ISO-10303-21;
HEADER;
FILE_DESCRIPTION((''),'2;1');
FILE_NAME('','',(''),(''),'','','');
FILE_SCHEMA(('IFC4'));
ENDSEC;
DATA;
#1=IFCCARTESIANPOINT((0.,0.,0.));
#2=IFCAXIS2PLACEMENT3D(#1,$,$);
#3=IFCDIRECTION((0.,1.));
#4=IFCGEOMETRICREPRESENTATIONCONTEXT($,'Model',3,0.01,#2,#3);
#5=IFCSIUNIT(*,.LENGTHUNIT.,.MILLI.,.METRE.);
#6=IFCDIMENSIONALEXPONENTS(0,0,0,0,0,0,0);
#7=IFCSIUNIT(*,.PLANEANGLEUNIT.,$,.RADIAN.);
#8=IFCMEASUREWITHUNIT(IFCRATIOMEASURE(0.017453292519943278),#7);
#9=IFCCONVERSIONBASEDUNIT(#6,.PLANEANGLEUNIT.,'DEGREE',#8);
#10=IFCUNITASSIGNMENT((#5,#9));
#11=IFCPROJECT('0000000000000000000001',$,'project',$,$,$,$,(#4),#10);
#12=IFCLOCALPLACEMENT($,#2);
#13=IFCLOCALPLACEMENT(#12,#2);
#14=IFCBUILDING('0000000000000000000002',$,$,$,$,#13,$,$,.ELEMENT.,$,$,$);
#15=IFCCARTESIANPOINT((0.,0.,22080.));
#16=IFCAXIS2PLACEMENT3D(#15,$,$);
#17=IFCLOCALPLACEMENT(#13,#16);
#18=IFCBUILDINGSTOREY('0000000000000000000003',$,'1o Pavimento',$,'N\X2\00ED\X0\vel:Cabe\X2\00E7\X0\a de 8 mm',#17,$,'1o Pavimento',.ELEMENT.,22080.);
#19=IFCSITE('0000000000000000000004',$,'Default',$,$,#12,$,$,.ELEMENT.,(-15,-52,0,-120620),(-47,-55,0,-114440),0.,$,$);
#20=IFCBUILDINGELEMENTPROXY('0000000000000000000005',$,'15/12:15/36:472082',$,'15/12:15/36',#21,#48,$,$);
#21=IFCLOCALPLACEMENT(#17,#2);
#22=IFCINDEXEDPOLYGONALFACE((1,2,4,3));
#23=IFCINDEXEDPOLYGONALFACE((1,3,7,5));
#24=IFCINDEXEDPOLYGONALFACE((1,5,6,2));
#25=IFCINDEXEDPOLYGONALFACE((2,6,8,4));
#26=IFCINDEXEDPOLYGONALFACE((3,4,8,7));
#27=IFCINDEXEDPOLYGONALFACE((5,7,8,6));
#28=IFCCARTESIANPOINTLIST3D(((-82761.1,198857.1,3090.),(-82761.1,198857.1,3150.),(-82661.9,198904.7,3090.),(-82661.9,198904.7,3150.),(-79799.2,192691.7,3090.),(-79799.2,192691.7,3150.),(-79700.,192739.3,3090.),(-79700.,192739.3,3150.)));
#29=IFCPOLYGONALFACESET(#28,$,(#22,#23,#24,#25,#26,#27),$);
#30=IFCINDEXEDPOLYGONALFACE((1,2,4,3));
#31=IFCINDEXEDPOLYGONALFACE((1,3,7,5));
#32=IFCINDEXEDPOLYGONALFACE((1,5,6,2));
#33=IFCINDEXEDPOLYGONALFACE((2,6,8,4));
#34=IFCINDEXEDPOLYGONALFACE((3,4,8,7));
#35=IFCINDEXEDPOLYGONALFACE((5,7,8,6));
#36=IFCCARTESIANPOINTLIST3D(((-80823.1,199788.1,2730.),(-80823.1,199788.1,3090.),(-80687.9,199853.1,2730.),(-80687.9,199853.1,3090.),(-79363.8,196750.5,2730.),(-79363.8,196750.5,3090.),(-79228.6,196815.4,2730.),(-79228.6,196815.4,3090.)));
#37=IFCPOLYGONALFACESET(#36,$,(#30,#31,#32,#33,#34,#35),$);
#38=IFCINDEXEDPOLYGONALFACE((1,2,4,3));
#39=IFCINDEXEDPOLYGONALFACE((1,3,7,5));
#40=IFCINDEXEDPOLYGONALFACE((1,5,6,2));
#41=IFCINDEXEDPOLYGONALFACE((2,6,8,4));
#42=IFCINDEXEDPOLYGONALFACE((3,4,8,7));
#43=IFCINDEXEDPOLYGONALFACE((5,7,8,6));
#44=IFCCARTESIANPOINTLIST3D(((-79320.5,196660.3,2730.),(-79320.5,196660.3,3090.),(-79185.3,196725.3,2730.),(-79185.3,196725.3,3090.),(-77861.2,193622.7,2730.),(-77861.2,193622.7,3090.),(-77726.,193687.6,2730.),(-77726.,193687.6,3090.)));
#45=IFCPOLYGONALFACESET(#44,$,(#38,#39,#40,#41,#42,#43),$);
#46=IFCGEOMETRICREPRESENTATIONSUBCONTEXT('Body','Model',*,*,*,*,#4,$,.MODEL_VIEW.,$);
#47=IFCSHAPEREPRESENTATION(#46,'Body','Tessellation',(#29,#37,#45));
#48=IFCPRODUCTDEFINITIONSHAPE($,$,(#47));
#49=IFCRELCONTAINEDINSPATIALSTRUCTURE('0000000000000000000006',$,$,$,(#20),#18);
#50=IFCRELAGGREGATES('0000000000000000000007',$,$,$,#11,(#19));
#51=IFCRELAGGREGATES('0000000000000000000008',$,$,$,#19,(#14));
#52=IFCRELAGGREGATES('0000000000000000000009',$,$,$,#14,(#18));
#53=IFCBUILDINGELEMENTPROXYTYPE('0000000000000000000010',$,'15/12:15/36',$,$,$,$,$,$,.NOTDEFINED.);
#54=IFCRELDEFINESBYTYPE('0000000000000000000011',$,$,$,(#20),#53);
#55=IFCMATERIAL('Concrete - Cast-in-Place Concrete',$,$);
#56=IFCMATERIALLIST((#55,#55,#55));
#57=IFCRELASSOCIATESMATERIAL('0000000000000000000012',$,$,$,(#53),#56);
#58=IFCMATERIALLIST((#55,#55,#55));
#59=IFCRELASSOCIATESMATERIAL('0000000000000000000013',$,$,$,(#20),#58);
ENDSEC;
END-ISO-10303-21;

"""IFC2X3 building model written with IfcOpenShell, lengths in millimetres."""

from ifc_helpers import new_model, entity, si_unit, converted_unit, direction, frame, frame_2d, origin, place, context, subcontext, project, spatial, rectangle, extrude, source, transform, mapped, material, material_list, type_object, type_shapes, element, save


model = new_model("IFC2X3")

# Units and contexts
model_context = context("Model", 3, precision=0.01, world=origin(), true_north=direction((0.0, 1.0)))
body_context = subcontext(model_context, "Body", "Model", "MODEL_VIEW")
ifc_project = project(units=[si_unit("LENGTHUNIT", "METRE", prefix="MILLI"), converted_unit("PLANEANGLEUNIT", "DEGREE", entity("IfcRatioMeasure", 0.017453292519943278), si_unit("PLANEANGLEUNIT", "RADIAN"), dimensions=[0, 0, 0, 0, 0, 0, 0])], contexts=[model_context])

# Site, building, storey
site_placement = place(None, origin())
site = spatial("IfcSite", under=ifc_project, at=site_placement, Name="Default", CompositionType="ELEMENT", RefLatitude=(-15, -52, 0, -120620), RefLongitude=(-47, -55, 0, -114440), RefElevation=0.0)
building_placement = place(site_placement, origin())
building = spatial("IfcBuilding", under=site, at=building_placement, CompositionType="ELEMENT")
storey_placement = place(building_placement, frame((0.0, 0.0, 22080.0)))
storey = spatial("IfcBuildingStorey", under=building, at=storey_placement, Name="1o Pavimento", ObjectType="Nível:Cabeça de 8 mm", LongName="1o Pavimento", CompositionType="ELEMENT", Elevation=22080.0)

# Building element proxy
ifc_material_1 = material(Name="Concrete - Cast-in-Place Concrete")
ifc_material_list_1 = material_list([ifc_material_1, ifc_material_1, ifc_material_1])
ifc_material_list_2 = material_list([ifc_material_1, ifc_material_1, ifc_material_1])
building_element_proxy_type_1 = type_object("IfcBuildingElementProxyType", Name="15/12:15/36", PredefinedType="NOTDEFINED", material=ifc_material_list_2)
shared_shape_1 = source(origin(), body_context, "Body", "SweptSolid", [
    extrude(rectangle(XDim=110.0, YDim=6840.0, at=frame_2d((0.0, 0.0), x_axis=(1.0, 0.0))), frame((1530.5, 3106.5, 360.0), z_axis=(0.0, 0.0, 1.0), x_axis=(0.90138, 0.43303, 0.0)), (0.0, 0.0, 1.0), 60.0),
    extrude(rectangle(XDim=3370.0, YDim=150.0, at=frame_2d((0.0, 0.0), x_axis=(1.0, 0.0))), frame((2735.2, 5610.1, 0.0), z_axis=(0.0, 0.0, 1.0), x_axis=(0.43303, -0.90138, 0.0)), (0.0, 0.0, 1.0), 360.0),
    extrude(rectangle(XDim=3370.0, YDim=150.0, at=frame_2d((0.0, 0.0), x_axis=(1.0, 0.0))), frame((4237.8, 2482.3, 0.0), z_axis=(0.0, 0.0, 1.0), x_axis=(0.43303, -0.90138, 0.0)), (0.0, 0.0, 1.0), 360.0),
])
type_shapes(building_element_proxy_type_1, [shared_shape_1])
proxy_1_placement = place(storey_placement, frame((-82761.1, 192691.7, 2730.0)))
element("IfcBuildingElementProxy", 1, at=proxy_1_placement, inside=storey, type_object=building_element_proxy_type_1, material=ifc_material_list_1, Name="15/12:15/36:472082", ObjectType="15/12:15/36", context=body_context, shape_type="MappedRepresentation", body=[
    mapped(shared_shape_1, transform((0.0, 0.0, 0.0), scale=1.0)),
])

save(model, "model.ifc")
